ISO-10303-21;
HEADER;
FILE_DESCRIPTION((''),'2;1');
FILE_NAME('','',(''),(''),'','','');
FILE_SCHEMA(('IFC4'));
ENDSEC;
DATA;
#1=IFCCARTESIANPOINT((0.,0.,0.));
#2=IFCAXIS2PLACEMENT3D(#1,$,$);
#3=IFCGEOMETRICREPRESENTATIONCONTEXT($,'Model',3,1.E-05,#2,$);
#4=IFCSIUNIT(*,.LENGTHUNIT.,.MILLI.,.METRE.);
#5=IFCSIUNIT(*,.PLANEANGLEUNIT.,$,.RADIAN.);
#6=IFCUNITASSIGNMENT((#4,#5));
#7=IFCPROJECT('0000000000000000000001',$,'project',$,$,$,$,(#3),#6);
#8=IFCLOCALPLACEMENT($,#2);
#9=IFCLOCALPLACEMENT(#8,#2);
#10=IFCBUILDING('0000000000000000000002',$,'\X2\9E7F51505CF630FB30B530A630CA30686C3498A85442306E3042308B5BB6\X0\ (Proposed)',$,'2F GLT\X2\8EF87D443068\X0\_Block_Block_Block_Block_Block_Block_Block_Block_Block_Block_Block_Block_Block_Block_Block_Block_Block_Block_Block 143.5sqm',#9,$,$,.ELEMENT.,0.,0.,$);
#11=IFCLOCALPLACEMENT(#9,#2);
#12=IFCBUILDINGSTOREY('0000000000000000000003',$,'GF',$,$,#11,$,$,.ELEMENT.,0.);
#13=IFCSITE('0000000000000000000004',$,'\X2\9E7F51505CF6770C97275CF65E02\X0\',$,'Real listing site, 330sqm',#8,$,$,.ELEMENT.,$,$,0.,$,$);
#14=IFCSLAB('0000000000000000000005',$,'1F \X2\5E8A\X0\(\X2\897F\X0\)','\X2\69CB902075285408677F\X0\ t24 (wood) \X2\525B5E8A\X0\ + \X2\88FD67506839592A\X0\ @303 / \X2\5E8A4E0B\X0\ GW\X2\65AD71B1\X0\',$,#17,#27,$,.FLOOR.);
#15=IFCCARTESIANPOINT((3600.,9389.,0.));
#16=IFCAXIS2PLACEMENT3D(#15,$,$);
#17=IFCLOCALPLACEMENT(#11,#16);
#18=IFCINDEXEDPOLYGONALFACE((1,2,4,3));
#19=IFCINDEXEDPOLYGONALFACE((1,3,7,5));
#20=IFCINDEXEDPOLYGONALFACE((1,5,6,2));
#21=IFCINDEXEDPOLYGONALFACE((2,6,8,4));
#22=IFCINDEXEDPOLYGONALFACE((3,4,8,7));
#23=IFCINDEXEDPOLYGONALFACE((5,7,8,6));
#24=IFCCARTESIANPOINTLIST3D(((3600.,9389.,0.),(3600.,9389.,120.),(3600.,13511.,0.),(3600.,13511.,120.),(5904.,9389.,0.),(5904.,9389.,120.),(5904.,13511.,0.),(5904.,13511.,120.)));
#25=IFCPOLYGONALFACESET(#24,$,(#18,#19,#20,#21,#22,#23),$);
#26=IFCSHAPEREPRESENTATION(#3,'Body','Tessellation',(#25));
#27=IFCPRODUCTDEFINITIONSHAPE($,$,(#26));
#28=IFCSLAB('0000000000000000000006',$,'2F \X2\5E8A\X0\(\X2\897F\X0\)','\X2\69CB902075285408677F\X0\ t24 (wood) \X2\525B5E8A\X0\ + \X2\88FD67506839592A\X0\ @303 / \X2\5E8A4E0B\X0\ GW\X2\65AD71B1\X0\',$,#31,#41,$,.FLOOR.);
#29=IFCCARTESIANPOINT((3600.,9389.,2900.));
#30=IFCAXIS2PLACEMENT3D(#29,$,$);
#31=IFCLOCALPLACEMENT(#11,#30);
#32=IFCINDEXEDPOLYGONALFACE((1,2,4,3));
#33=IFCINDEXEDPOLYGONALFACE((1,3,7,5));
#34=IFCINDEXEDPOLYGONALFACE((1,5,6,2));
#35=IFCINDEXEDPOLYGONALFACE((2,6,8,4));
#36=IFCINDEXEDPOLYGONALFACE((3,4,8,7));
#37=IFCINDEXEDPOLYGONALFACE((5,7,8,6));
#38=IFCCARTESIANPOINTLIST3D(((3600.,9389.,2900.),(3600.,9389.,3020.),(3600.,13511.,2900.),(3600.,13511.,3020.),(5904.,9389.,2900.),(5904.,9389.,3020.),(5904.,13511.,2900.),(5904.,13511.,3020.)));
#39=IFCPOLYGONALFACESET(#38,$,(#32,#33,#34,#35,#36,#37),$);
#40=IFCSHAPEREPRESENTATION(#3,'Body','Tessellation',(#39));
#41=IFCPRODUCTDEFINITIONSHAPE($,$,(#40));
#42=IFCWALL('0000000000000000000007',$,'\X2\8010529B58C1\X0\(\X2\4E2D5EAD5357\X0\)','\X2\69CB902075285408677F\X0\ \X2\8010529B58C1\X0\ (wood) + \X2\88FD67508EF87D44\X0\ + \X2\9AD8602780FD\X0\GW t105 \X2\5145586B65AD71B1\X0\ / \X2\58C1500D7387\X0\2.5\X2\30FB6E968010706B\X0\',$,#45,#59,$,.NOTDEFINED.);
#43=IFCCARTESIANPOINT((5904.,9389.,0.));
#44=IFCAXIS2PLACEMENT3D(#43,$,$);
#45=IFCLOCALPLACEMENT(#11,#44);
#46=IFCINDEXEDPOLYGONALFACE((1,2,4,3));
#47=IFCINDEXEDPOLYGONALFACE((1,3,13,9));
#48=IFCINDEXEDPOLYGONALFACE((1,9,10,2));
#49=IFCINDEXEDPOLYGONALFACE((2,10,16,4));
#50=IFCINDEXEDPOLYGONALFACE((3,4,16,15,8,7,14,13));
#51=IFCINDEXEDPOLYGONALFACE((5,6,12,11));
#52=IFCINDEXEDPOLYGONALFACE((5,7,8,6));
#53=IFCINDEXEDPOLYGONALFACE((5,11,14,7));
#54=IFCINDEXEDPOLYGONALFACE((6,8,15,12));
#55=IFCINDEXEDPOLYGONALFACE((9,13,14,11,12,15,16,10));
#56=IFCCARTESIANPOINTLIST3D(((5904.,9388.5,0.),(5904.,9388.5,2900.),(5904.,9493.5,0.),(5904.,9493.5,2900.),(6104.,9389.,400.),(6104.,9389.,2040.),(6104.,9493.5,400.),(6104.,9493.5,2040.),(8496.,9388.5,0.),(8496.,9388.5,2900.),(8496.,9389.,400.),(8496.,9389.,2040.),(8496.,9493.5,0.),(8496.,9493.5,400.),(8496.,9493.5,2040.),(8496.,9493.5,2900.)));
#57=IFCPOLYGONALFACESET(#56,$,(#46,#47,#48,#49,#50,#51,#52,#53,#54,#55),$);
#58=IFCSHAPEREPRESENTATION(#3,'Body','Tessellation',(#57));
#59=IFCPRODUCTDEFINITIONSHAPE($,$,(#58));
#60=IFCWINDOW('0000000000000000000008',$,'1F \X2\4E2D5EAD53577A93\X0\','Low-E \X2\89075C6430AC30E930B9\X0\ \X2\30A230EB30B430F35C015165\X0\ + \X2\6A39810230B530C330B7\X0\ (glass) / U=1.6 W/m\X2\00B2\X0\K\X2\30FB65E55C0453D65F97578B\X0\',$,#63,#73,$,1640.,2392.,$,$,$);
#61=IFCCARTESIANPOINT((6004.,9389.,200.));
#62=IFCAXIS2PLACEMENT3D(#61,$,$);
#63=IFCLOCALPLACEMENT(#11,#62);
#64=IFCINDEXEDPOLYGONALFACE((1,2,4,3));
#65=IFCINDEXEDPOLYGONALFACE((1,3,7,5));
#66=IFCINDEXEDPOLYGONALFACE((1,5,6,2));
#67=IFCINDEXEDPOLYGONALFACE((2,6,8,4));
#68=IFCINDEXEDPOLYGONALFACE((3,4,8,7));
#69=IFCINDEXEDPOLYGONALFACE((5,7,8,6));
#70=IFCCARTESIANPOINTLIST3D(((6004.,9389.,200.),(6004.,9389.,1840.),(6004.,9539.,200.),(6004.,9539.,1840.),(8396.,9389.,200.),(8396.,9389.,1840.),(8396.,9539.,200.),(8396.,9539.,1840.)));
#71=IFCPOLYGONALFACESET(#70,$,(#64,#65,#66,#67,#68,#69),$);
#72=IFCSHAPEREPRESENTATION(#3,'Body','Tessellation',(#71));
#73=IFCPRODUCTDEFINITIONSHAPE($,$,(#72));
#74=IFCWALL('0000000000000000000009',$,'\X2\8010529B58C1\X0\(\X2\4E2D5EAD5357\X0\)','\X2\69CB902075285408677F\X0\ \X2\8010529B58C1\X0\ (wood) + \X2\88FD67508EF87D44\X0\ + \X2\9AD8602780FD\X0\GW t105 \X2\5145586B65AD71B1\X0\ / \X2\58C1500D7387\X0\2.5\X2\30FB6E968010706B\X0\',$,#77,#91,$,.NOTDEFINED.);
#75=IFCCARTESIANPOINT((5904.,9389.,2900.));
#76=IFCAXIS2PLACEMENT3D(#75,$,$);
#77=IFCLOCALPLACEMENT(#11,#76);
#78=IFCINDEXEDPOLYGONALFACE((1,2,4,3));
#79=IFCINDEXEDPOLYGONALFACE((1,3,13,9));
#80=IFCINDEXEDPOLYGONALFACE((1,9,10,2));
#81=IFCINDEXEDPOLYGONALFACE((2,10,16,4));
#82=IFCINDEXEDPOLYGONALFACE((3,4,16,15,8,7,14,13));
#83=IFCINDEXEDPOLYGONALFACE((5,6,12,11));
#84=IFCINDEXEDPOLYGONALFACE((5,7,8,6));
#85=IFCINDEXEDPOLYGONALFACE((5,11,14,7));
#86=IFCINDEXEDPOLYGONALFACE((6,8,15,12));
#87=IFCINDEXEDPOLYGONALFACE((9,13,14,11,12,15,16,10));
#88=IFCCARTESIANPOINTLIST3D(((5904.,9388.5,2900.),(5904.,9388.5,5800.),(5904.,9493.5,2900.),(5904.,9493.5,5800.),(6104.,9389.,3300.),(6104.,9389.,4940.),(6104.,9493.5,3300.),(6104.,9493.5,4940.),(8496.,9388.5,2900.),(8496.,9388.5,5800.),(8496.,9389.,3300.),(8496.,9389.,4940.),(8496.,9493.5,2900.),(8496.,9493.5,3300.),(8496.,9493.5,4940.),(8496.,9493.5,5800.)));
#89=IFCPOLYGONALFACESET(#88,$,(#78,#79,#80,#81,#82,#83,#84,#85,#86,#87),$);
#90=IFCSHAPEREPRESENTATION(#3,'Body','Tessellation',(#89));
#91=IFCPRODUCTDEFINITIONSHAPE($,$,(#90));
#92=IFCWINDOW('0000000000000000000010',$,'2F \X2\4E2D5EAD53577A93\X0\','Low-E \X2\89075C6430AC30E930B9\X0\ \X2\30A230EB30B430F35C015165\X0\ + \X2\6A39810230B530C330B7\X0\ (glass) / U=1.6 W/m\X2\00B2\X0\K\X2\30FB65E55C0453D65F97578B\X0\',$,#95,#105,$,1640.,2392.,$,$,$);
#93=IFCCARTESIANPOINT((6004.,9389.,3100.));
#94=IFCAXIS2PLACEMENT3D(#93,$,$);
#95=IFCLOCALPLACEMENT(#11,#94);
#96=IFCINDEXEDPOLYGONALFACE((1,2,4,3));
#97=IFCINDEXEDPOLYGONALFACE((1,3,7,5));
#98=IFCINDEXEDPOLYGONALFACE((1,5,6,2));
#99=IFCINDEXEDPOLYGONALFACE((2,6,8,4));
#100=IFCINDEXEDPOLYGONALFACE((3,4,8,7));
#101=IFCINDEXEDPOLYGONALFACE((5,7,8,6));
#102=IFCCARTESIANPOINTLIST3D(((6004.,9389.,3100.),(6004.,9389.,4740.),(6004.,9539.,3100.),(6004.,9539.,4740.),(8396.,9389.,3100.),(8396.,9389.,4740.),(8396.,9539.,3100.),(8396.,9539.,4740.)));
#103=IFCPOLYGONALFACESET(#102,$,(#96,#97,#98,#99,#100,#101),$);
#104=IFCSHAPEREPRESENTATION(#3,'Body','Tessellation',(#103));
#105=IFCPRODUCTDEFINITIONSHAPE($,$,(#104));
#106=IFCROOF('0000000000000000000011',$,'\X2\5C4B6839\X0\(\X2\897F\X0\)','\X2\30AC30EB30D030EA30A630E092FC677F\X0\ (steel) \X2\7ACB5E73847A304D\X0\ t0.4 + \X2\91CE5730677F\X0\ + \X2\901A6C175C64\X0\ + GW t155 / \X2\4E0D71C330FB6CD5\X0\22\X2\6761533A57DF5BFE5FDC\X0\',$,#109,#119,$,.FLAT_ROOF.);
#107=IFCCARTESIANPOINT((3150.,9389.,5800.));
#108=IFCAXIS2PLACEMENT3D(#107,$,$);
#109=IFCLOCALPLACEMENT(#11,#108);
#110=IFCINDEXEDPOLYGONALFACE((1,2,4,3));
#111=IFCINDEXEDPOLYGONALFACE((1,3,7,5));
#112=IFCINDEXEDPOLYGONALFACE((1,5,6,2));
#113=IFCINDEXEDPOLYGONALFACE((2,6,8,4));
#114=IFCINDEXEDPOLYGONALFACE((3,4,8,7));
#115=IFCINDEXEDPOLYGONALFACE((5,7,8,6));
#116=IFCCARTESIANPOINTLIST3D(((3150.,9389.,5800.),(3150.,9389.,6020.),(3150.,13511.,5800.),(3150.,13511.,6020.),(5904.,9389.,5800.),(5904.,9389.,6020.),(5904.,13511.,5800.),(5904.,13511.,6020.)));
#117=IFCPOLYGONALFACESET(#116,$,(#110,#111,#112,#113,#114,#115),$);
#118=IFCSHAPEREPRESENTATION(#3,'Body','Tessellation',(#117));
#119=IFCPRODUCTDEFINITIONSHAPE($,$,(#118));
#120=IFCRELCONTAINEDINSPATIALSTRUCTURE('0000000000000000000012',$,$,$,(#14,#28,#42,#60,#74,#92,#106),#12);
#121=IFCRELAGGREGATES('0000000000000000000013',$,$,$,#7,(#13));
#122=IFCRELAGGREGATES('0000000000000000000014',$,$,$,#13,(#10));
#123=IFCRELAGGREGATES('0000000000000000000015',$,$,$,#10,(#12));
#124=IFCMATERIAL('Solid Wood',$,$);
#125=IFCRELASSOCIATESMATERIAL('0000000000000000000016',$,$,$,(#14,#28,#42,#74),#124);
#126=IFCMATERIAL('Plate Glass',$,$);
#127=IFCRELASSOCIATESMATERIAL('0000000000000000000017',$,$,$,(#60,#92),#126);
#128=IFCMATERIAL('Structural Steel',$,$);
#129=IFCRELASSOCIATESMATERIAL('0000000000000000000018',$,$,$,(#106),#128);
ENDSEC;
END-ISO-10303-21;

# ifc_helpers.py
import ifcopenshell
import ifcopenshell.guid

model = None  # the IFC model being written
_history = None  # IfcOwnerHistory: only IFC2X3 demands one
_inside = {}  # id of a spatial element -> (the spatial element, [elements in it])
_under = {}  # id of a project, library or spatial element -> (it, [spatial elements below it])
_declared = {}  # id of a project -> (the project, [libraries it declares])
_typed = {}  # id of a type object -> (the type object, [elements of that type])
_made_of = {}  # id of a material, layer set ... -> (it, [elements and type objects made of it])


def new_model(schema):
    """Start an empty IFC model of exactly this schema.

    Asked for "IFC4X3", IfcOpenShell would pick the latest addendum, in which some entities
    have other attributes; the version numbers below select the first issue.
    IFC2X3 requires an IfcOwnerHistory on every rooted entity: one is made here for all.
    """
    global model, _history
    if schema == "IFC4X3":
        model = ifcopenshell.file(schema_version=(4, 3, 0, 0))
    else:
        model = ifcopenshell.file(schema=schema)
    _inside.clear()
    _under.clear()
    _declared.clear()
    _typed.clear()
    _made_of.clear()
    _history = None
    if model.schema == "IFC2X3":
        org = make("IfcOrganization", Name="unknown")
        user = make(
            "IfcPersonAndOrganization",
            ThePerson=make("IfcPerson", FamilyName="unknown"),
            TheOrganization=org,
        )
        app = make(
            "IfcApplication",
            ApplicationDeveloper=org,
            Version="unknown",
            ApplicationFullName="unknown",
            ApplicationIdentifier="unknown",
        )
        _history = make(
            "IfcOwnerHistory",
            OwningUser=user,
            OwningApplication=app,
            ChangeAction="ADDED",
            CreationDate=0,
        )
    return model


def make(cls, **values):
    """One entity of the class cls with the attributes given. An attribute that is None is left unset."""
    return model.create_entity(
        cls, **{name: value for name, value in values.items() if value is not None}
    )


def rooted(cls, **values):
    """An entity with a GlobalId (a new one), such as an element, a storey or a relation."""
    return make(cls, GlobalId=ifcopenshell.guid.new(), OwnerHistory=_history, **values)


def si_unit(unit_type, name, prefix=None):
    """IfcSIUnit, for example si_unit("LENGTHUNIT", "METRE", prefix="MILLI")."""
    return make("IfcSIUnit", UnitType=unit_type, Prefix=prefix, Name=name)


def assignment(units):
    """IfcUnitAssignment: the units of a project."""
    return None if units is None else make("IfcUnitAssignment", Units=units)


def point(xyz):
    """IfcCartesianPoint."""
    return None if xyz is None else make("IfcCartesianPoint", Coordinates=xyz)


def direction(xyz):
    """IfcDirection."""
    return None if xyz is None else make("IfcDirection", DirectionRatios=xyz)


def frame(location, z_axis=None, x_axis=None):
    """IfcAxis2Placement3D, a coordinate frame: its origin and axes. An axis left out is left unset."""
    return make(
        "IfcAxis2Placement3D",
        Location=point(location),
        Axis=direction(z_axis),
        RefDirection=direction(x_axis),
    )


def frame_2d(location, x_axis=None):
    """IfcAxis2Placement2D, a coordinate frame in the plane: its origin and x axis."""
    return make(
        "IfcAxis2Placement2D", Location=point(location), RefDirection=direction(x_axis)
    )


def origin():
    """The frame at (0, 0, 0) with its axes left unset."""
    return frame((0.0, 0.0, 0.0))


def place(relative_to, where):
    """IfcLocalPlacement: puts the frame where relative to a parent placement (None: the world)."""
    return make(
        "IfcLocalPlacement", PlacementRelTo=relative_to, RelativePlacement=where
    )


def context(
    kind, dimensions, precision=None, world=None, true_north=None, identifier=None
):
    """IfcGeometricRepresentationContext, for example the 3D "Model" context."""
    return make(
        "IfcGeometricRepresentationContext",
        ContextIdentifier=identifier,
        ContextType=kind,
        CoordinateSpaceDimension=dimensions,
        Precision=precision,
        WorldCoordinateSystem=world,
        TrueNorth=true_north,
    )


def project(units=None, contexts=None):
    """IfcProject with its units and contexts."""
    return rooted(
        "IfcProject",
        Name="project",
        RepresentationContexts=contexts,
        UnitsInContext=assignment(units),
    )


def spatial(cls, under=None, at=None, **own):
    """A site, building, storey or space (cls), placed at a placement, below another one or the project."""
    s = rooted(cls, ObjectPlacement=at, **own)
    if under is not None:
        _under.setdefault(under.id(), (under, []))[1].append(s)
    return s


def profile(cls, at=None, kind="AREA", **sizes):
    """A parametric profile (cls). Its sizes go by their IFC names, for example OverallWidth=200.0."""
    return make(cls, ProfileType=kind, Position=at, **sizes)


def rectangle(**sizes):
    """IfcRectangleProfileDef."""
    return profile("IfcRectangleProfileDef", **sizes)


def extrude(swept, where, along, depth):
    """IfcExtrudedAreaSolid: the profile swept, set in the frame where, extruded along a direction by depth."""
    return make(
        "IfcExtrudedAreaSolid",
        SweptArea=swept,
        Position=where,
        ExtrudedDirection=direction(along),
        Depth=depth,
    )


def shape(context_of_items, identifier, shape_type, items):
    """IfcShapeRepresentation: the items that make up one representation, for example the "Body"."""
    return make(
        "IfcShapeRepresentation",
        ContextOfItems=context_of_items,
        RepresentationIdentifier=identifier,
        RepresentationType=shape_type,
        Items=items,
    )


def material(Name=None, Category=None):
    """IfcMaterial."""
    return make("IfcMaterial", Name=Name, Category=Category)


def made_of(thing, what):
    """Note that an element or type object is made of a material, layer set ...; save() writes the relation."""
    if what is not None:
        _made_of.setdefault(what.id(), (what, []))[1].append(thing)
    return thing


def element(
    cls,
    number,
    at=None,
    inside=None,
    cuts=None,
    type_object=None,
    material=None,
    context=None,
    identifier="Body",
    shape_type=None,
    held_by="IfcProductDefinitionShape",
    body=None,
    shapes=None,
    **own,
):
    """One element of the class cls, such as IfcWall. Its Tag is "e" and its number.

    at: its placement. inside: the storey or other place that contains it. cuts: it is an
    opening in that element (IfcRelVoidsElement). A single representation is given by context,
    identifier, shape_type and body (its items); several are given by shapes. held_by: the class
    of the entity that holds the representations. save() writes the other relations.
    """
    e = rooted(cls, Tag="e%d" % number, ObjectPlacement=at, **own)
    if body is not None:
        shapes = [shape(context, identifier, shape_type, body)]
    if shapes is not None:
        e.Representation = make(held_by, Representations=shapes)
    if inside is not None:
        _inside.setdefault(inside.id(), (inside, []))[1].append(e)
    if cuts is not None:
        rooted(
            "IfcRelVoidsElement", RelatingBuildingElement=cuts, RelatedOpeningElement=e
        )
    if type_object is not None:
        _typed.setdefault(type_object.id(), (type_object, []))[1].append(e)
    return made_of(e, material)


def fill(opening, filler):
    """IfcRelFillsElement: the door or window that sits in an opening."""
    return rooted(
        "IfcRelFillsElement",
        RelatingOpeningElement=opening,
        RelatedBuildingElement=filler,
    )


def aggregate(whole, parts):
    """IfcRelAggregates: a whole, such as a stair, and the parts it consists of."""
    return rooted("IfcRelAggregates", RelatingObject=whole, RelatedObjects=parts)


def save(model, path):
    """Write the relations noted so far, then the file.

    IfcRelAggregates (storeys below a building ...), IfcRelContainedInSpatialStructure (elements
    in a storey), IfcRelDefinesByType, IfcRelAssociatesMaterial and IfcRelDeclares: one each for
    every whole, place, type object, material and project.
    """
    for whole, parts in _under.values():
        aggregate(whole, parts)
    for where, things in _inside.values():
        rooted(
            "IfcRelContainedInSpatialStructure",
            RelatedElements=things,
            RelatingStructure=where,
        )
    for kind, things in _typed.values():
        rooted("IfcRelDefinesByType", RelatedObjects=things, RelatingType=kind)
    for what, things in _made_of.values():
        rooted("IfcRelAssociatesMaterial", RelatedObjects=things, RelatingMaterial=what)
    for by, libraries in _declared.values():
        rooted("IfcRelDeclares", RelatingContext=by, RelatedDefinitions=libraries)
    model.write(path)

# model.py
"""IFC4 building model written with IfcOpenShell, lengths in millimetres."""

from ifc_helpers import new_model, si_unit, frame, frame_2d, origin, place, context, project, spatial, rectangle, extrude, material, element, fill, save


model = new_model("IFC4")

# Units and contexts
model_context = context("Model", 3, precision=1e-05, world=origin())
ifc_project = project(units=[si_unit("LENGTHUNIT", "METRE", prefix="MILLI"), si_unit("PLANEANGLEUNIT", "RADIAN")], contexts=[model_context])

# Site, building, storey
site_placement = place(None, origin())
site = spatial("IfcSite", under=ifc_project, at=site_placement, Name="鹿児島県霧島市", ObjectType="Real listing site, 330sqm", CompositionType="ELEMENT", RefElevation=0.0)
building_placement = place(site_placement, origin())
building = spatial("IfcBuilding", under=site, at=building_placement, Name="鹿児島・サウナと水風呂のある家 (Proposed)", ObjectType="2F GLT軸組と_Block_Block_Block_Block_Block_Block_Block_Block_Block_Block_Block_Block_Block_Block_Block_Block_Block_Block_Block 143.5sqm", CompositionType="ELEMENT", ElevationOfRefHeight=0.0, ElevationOfTerrain=0.0)
storey_placement = place(building_placement, origin())
storey = spatial("IfcBuildingStorey", under=building, at=storey_placement, Name="GF", CompositionType="ELEMENT", Elevation=0.0)

# Shared definitions
ifc_material_1 = material(Name="Solid Wood")

# Slabs
slab_1_placement = place(storey_placement, frame((3600.0, 9389.0, 0.0)))
element("IfcSlab", 1, at=slab_1_placement, inside=storey, material=ifc_material_1, Name="1F 床(西)", Description="構造用合板 t24 (wood) 剛床 + 製材根太 @303 / 床下 GW断熱", PredefinedType="FLOOR", context=model_context, shape_type="SweptSolid", body=[
    extrude(rectangle(XDim=2304.0, YDim=4122.0, at=frame_2d((1152.0, 2061.0))), frame((3600.0, 9389.0, 0.0)), (0.0, 0.0, 1.0), 120.0),
])
slab_2_placement = place(storey_placement, frame((3600.0, 9389.0, 2900.0)))
element("IfcSlab", 2, at=slab_2_placement, inside=storey, material=ifc_material_1, Name="2F 床(西)", Description="構造用合板 t24 (wood) 剛床 + 製材根太 @303 / 床下 GW断熱", PredefinedType="FLOOR", context=model_context, shape_type="SweptSolid", body=[
    extrude(rectangle(XDim=2304.0, YDim=4122.0, at=frame_2d((1152.0, 2061.0))), frame((3600.0, 9389.0, 2900.0)), (0.0, 0.0, 1.0), 120.0),
])

# Wall, opening, window
wall_1_placement = place(storey_placement, frame((5904.0, 9389.0, 0.0)))
wall_1 = element("IfcWall", 3, at=wall_1_placement, inside=storey, material=ifc_material_1, Name="耐力壁(中庭南)", Description="構造用合板 耐力壁 (wood) + 製材軸組 + 高性能GW t105 充填断熱 / 壁倍率2.5・準耐火", PredefinedType="NOTDEFINED", context=model_context, shape_type="SweptSolid", body=[
    extrude(rectangle(XDim=2592.0, YDim=105.0, at=frame_2d((1296.0, 52.0))), frame((5904.0, 9389.0, 0.0)), (0.0, 0.0, 1.0), 2900.0),
])
opening_1_placement = place(storey_placement, frame((6004.0, 9389.0, 200.0)))
opening_1 = element("IfcOpeningElement", 4, at=opening_1_placement, cuts=wall_1, PredefinedType="NOTDEFINED", context=model_context, shape_type="SweptSolid", body=[
    extrude(rectangle(XDim=2392.0, YDim=150.0, at=frame_2d((1196.0, 75.0))), frame((6004.0, 9389.0, 200.0)), (0.0, 0.0, 1.0), 1640.0),
])
ifc_material_2 = material(Name="Plate Glass")
window_1_placement = place(storey_placement, frame((6004.0, 9389.0, 200.0)))
window_1 = element("IfcWindow", 5, at=window_1_placement, inside=storey, material=ifc_material_2, Name="1F 中庭南窓", Description="Low-E 複層ガラス アルゴン封入 + 樹脂サッシ (glass) / U=1.6 W/m²K・日射取得型", OverallHeight=1640.0, OverallWidth=2392.0, context=model_context, shape_type="SweptSolid", body=[
    extrude(rectangle(XDim=2392.0, YDim=150.0, at=frame_2d((1196.0, 75.0))), frame((6004.0, 9389.0, 200.0)), (0.0, 0.0, 1.0), 1640.0),
])
fill(opening_1, window_1)

# Wall, opening, window
wall_2_placement = place(storey_placement, frame((5904.0, 9389.0, 2900.0)))
wall_2 = element("IfcWall", 6, at=wall_2_placement, inside=storey, material=ifc_material_1, Name="耐力壁(中庭南)", Description="構造用合板 耐力壁 (wood) + 製材軸組 + 高性能GW t105 充填断熱 / 壁倍率2.5・準耐火", PredefinedType="NOTDEFINED", context=model_context, shape_type="SweptSolid", body=[
    extrude(rectangle(XDim=2592.0, YDim=105.0, at=frame_2d((1296.0, 52.0))), frame((5904.0, 9389.0, 2900.0)), (0.0, 0.0, 1.0), 2900.0),
])
opening_2_placement = place(storey_placement, frame((6004.0, 9389.0, 3100.0)))
opening_2 = element("IfcOpeningElement", 7, at=opening_2_placement, cuts=wall_2, PredefinedType="NOTDEFINED", context=model_context, shape_type="SweptSolid", body=[
    extrude(rectangle(XDim=2392.0, YDim=150.0, at=frame_2d((1196.0, 75.0))), frame((6004.0, 9389.0, 3100.0)), (0.0, 0.0, 1.0), 1640.0),
])
window_2_placement = place(storey_placement, frame((6004.0, 9389.0, 3100.0)))
window_2 = element("IfcWindow", 8, at=window_2_placement, inside=storey, material=ifc_material_2, Name="2F 中庭南窓", Description="Low-E 複層ガラス アルゴン封入 + 樹脂サッシ (glass) / U=1.6 W/m²K・日射取得型", OverallHeight=1640.0, OverallWidth=2392.0, context=model_context, shape_type="SweptSolid", body=[
    extrude(rectangle(XDim=2392.0, YDim=150.0, at=frame_2d((1196.0, 75.0))), frame((6004.0, 9389.0, 3100.0)), (0.0, 0.0, 1.0), 1640.0),
])
fill(opening_2, window_2)

# Roof
ifc_material_3 = material(Name="Structural Steel")
for number, where, name in (
    (9, (3150.0, 9389.0, 5800.0), "屋根(西)"),
):
    element("IfcRoof", number, at=place(storey_placement, frame(where)), inside=storey, material=ifc_material_3, Name=name, Description="ガルバリウム鋼板 (steel) 立平葺き t0.4 + 野地板 + 通気層 + GW t155 / 不燃・法22条区域対応", PredefinedType="FLAT_ROOF", context=model_context, shape_type="SweptSolid", body=[
        extrude(rectangle(XDim=2754.0, YDim=4122.0, at=frame_2d((1377.0, 2061.0))), frame((3150.0, 9389.0, 5800.0)), (0.0, 0.0, 1.0), 220.0),
    ])

save(model, "model.ifc")
